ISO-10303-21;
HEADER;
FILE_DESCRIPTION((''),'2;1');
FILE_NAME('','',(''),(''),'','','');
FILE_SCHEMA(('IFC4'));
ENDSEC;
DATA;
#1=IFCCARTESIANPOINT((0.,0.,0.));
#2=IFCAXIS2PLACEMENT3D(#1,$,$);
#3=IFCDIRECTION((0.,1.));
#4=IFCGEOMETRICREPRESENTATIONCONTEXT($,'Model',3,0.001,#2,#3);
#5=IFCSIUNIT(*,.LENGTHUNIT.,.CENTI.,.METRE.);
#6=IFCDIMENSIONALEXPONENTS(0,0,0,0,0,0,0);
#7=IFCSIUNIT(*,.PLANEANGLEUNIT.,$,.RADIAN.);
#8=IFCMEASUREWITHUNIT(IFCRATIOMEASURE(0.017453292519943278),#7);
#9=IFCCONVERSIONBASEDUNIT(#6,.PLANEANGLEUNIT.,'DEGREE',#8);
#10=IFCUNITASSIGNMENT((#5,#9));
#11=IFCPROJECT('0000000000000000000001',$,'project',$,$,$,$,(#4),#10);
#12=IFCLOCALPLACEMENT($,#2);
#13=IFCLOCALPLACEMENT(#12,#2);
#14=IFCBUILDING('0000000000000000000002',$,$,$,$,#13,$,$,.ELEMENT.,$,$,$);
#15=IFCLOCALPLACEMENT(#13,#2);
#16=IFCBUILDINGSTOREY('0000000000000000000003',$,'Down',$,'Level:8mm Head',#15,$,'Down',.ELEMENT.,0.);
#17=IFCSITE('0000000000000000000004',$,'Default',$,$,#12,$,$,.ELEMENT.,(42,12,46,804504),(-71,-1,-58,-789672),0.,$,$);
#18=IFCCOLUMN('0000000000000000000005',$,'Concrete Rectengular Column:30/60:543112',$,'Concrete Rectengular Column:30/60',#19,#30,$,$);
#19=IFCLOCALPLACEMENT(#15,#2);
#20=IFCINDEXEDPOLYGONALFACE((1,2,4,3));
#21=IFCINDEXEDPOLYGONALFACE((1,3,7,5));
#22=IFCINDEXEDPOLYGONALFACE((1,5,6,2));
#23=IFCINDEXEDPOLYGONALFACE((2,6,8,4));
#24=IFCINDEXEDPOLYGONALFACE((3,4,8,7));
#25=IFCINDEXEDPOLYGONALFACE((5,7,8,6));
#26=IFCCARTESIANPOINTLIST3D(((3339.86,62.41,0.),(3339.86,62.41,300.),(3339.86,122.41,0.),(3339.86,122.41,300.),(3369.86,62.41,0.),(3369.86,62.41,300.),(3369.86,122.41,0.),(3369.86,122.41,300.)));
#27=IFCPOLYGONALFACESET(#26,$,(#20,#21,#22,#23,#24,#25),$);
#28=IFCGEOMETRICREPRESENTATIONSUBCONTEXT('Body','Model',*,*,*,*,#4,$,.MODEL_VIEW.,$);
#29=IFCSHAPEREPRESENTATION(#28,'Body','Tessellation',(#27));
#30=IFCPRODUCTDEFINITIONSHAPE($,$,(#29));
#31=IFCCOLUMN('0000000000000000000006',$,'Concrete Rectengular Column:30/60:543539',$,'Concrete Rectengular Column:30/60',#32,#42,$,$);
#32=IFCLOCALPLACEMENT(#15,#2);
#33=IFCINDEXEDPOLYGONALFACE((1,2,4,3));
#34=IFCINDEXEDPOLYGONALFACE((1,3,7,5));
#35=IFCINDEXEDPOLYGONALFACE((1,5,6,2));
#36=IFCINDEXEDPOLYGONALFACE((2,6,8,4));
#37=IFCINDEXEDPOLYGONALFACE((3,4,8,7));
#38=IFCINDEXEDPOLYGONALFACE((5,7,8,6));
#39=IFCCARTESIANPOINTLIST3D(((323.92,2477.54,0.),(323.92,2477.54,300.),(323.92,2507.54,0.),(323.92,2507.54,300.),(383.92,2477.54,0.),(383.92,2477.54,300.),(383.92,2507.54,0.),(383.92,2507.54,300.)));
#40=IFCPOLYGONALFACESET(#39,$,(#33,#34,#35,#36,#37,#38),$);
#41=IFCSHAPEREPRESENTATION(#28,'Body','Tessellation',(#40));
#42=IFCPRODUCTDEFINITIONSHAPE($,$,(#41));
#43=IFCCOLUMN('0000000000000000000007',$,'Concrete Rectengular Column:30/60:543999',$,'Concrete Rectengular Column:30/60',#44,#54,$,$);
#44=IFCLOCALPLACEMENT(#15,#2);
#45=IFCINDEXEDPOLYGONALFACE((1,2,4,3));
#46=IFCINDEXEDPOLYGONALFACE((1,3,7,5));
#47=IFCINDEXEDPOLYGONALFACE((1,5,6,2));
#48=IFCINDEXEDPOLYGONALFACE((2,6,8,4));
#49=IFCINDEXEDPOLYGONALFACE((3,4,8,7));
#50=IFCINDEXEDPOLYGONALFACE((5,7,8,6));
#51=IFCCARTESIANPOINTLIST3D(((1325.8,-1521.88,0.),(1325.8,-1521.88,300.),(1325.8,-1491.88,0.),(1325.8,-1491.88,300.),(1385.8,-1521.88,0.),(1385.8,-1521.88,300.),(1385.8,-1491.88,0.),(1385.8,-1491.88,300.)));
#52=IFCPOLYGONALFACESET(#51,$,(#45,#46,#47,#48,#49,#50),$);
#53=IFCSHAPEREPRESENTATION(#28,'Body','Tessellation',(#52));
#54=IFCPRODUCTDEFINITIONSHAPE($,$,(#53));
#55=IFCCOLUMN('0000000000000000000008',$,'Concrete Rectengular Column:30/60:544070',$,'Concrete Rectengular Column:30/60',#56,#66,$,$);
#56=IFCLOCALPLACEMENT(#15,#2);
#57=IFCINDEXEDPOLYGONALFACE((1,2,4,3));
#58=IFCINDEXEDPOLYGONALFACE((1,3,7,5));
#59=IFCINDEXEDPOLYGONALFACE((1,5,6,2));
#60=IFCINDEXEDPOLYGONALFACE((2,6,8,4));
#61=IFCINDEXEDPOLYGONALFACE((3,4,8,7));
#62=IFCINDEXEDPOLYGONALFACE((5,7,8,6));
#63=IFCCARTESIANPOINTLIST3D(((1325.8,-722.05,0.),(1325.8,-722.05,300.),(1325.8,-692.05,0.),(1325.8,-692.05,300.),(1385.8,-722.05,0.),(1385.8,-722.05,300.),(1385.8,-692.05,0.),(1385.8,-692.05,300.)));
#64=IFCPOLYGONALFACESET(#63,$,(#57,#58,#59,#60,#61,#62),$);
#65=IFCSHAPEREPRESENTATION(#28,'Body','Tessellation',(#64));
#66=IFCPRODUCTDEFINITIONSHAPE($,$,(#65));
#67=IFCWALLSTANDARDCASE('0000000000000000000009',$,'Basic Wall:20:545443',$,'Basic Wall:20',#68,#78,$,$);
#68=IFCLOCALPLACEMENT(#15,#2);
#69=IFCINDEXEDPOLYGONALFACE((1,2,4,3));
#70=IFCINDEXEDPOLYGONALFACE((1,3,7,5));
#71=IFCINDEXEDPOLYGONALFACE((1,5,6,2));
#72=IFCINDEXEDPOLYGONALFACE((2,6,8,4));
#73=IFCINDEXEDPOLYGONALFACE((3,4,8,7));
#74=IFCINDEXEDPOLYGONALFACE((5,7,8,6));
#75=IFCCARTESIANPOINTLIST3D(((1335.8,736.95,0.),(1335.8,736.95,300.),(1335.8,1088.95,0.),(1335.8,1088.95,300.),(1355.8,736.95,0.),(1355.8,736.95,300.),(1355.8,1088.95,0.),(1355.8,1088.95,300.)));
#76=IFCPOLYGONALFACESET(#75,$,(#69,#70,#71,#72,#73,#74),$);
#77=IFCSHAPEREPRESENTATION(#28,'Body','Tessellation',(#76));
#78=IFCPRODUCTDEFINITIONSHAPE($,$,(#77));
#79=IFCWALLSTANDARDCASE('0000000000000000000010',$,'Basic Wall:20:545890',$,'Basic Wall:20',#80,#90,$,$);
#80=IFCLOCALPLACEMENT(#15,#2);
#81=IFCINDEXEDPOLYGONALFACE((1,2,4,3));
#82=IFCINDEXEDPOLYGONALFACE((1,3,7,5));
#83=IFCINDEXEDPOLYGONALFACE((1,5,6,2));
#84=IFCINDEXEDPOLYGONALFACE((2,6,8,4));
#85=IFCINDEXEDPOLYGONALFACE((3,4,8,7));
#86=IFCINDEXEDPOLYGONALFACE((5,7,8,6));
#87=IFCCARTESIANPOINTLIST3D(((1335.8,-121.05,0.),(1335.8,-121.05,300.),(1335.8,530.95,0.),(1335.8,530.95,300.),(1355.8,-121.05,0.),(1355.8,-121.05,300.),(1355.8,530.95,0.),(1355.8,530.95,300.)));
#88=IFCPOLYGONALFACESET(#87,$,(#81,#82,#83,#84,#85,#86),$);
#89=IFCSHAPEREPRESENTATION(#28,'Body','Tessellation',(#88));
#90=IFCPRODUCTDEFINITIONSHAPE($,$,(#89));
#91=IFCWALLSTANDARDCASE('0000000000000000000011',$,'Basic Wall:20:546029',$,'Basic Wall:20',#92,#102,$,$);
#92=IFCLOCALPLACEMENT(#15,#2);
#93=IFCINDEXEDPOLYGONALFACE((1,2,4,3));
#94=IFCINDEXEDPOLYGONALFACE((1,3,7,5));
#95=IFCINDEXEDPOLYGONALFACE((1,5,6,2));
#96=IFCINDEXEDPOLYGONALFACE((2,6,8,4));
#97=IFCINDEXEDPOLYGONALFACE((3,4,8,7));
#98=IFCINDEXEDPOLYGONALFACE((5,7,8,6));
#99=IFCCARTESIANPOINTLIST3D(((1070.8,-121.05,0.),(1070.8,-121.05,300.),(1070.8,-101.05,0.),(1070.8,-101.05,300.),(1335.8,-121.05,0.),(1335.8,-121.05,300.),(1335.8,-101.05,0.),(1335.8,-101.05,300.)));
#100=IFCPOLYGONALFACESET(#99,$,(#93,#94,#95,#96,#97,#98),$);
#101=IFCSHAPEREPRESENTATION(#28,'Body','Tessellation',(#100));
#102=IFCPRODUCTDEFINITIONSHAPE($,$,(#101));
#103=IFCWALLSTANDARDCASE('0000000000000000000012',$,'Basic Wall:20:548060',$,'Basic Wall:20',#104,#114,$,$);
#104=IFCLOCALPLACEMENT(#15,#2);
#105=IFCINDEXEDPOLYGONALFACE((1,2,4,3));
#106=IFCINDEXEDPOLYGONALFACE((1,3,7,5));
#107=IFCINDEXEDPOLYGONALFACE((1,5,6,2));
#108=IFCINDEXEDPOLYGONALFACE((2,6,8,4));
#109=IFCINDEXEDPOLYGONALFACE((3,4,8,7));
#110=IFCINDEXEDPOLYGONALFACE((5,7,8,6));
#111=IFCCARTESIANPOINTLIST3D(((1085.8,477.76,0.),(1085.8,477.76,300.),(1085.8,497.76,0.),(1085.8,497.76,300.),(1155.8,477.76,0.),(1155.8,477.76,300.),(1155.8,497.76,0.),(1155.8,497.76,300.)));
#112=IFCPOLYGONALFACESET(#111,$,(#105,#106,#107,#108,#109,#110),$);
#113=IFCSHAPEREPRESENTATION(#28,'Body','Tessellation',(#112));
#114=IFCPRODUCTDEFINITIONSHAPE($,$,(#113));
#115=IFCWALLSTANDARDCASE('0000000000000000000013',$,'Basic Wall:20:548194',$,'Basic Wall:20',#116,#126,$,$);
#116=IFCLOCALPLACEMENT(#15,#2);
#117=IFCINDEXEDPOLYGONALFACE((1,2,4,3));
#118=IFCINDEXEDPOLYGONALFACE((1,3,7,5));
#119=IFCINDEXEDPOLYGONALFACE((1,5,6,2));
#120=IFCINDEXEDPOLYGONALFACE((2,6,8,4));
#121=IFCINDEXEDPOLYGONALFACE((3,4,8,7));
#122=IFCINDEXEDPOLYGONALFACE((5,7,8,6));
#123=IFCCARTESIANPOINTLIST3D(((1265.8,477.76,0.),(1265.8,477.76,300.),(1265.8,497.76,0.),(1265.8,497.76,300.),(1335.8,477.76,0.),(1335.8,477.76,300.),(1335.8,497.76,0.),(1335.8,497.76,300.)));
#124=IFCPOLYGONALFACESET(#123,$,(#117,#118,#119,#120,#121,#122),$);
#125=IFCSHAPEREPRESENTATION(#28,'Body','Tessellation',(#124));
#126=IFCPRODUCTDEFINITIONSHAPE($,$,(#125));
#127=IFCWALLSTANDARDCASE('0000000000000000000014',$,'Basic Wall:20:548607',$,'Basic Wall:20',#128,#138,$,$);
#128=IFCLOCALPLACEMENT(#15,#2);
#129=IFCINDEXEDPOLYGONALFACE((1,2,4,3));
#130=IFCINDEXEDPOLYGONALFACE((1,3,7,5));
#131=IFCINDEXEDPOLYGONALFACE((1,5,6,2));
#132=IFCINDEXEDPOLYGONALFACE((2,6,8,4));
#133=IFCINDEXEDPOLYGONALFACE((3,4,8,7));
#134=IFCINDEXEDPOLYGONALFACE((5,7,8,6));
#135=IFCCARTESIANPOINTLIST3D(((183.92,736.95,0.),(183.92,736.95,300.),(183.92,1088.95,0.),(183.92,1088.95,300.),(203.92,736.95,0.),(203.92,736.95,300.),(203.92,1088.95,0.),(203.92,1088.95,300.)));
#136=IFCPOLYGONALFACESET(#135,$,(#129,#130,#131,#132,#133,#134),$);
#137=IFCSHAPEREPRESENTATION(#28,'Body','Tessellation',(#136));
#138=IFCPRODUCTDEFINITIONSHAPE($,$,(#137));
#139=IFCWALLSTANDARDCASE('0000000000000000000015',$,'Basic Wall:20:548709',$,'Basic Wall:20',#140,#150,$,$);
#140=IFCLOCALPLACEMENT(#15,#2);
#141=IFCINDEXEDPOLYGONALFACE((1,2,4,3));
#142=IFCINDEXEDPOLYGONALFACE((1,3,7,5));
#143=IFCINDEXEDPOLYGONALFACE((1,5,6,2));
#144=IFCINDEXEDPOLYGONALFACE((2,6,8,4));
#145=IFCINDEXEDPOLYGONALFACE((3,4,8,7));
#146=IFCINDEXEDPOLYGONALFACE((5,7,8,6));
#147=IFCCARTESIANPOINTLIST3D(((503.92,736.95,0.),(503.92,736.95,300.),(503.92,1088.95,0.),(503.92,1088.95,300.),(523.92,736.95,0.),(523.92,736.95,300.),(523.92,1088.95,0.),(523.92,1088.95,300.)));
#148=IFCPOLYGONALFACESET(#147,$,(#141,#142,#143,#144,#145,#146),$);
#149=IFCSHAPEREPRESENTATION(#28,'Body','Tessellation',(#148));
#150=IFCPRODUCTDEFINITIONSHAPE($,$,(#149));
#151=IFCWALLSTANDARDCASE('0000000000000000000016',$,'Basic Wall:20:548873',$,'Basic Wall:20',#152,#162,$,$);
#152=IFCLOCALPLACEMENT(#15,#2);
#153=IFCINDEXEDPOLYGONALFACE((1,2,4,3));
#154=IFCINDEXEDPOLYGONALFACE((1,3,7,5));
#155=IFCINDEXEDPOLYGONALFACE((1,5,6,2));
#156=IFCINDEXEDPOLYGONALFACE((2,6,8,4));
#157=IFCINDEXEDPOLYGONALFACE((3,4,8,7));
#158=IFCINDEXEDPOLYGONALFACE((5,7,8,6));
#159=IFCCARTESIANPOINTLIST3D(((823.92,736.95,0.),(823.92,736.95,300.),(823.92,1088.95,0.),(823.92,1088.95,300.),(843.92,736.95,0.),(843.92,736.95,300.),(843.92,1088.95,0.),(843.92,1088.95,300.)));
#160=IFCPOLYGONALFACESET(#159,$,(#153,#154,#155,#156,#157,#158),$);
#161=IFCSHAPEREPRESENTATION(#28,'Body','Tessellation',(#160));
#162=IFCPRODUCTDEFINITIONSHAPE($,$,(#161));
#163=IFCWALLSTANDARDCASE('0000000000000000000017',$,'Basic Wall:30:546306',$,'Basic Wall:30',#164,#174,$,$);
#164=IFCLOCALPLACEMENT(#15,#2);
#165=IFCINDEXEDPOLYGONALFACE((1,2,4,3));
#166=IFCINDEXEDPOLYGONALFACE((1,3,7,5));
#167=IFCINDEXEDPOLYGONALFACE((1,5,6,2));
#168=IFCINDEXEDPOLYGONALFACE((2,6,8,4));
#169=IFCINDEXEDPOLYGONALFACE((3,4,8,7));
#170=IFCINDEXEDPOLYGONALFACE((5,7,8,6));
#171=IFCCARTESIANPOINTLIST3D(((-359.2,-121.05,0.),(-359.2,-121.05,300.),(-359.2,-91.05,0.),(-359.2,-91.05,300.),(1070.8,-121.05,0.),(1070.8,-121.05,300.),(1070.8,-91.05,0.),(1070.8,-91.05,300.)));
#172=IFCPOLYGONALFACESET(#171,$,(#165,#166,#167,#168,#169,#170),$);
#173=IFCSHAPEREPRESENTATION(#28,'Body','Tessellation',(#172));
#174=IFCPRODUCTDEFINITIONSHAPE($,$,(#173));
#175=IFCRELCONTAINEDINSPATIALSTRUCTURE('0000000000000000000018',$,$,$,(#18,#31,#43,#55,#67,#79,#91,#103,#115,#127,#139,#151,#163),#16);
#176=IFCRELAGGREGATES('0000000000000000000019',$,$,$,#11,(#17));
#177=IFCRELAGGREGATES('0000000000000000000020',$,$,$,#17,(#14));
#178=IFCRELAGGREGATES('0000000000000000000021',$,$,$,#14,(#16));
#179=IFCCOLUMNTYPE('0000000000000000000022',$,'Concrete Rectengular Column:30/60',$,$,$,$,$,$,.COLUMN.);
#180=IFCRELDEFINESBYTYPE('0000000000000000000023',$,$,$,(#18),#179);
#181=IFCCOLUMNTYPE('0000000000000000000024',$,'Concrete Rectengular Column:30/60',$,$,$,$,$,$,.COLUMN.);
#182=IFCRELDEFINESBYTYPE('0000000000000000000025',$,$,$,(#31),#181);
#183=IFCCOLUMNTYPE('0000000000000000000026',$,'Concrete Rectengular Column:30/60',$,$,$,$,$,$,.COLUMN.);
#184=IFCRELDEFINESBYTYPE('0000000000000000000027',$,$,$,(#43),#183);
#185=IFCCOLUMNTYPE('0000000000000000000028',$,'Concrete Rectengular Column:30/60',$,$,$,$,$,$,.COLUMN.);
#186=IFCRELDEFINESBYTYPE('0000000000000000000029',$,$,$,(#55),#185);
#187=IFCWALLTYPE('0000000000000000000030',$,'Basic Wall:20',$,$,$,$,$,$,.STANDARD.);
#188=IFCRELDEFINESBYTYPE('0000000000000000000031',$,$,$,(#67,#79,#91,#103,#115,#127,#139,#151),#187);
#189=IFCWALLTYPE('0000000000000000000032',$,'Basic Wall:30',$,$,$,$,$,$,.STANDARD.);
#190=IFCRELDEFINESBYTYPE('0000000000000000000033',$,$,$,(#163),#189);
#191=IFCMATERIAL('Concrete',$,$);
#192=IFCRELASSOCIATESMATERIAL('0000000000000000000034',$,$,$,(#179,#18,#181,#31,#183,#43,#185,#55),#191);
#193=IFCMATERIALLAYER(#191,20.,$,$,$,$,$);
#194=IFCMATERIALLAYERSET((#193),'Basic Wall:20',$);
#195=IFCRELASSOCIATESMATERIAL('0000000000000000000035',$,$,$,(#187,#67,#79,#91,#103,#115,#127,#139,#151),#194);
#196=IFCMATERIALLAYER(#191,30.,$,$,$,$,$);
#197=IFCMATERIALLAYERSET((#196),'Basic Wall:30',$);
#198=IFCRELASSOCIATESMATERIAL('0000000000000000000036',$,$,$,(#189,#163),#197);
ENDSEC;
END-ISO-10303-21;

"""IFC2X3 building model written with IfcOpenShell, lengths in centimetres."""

from ifc_helpers import new_model, entity, si_unit, converted_unit, direction, frame, frame_2d, origin, origin_2d_with_axis, place, context, subcontext, project, spatial, rectangle, extrude, source, transform, mapped, material, layer, layer_set, layer_usage, type_object, type_shapes, element, save


model = new_model("IFC2X3")

# Units and contexts
model_context = context("Model", 3, precision=0.001, world=origin(), true_north=direction((0.0, 1.0)))
body_context = subcontext(model_context, "Body", "Model", "MODEL_VIEW")
ifc_project = project(units=[si_unit("LENGTHUNIT", "METRE", prefix="CENTI"), converted_unit("PLANEANGLEUNIT", "DEGREE", entity("IfcRatioMeasure", 0.017453292519943278), si_unit("PLANEANGLEUNIT", "RADIAN"), dimensions=[0, 0, 0, 0, 0, 0, 0])], contexts=[model_context])

# Site, building, storey
site_placement = place(None, origin())
site = spatial("IfcSite", under=ifc_project, at=site_placement, Name="Default", CompositionType="ELEMENT", RefLatitude=(42, 12, 46, 804504), RefLongitude=(-71, -1, -58, -789672), RefElevation=0.0)
building_placement = place(site_placement, origin())
building = spatial("IfcBuilding", under=site, at=building_placement, CompositionType="ELEMENT")
storey_placement = place(building_placement, origin())
storey = spatial("IfcBuildingStorey", under=building, at=storey_placement, Name="Down", ObjectType="Level:8mm Head", LongName="Down", CompositionType="ELEMENT", Elevation=0.0)

# Columns
ifc_material = material(Name="Concrete")
column_type_1 = type_object("IfcColumnType", Name="Concrete Rectengular Column:30/60", PredefinedType="COLUMN", material=ifc_material)
shared_shape_1 = source(origin(), body_context, "Body", "SweptSolid", [
    extrude(rectangle(XDim=60.0, YDim=30.0, at=origin_2d_with_axis()), frame((3354.86, 92.41, 0.0), z_axis=(0.0, 0.0, 1.0), x_axis=(0.0, -1.0, 0.0)), (0.0, 0.0, 1.0), 300.0),
])
type_shapes(column_type_1, [shared_shape_1])
column_1_placement = place(storey_placement, origin())
element("IfcColumn", 1, at=column_1_placement, inside=storey, type_object=column_type_1, material=ifc_material, Name="Concrete Rectengular Column:30/60:543112", ObjectType="Concrete Rectengular Column:30/60", context=body_context, shape_type="MappedRepresentation", body=[
    mapped(shared_shape_1, transform((0.0, 0.0, 0.0), scale=1.0)),
])
column_type_2 = type_object("IfcColumnType", Name="Concrete Rectengular Column:30/60", PredefinedType="COLUMN", material=ifc_material)
shared_shape_2 = source(origin(), body_context, "Body", "SweptSolid", [
    extrude(rectangle(XDim=30.0, YDim=60.0, at=origin_2d_with_axis()), frame((353.92, 2492.54, 0.0), z_axis=(0.0, 0.0, 1.0), x_axis=(0.0, -1.0, 0.0)), (0.0, 0.0, 1.0), 300.0),
])
type_shapes(column_type_2, [shared_shape_2])
column_2_placement = place(storey_placement, origin())
element("IfcColumn", 2, at=column_2_placement, inside=storey, type_object=column_type_2, material=ifc_material, Name="Concrete Rectengular Column:30/60:543539", ObjectType="Concrete Rectengular Column:30/60", context=body_context, shape_type="MappedRepresentation", body=[
    mapped(shared_shape_2, transform((0.0, 0.0, 0.0), scale=1.0)),
])
column_type_3 = type_object("IfcColumnType", Name="Concrete Rectengular Column:30/60", PredefinedType="COLUMN", material=ifc_material)
shared_shape_3 = source(origin(), body_context, "Body", "SweptSolid", [
    extrude(rectangle(XDim=30.0, YDim=60.0, at=frame_2d((0.0, 0.0), x_axis=(1.0, 0.0))), frame((1355.8, -1506.88, 0.0), z_axis=(0.0, 0.0, 1.0), x_axis=(0.0, -1.0, 0.0)), (0.0, 0.0, 1.0), 300.0),
])
type_shapes(column_type_3, [shared_shape_3])
column_3_placement = place(storey_placement, origin())
element("IfcColumn", 3, at=column_3_placement, inside=storey, type_object=column_type_3, material=ifc_material, Name="Concrete Rectengular Column:30/60:543999", ObjectType="Concrete Rectengular Column:30/60", context=body_context, shape_type="MappedRepresentation", body=[
    mapped(shared_shape_3, transform((0.0, 0.0, 0.0), scale=1.0)),
])
column_type_4 = type_object("IfcColumnType", Name="Concrete Rectengular Column:30/60", PredefinedType="COLUMN", material=ifc_material)
shared_shape_4 = source(origin(), body_context, "Body", "SweptSolid", [
    extrude(rectangle(XDim=30.0, YDim=60.0, at=frame_2d((0.0, 0.0), x_axis=(1.0, 0.0))), frame((1355.8, -707.05, 0.0), z_axis=(0.0, 0.0, 1.0), x_axis=(0.0, -1.0, 0.0)), (0.0, 0.0, 1.0), 300.0),
])
type_shapes(column_type_4, [shared_shape_4])
column_4_placement = place(storey_placement, origin())
element("IfcColumn", 4, at=column_4_placement, inside=storey, type_object=column_type_4, material=ifc_material, Name="Concrete Rectengular Column:30/60:544070", ObjectType="Concrete Rectengular Column:30/60", context=body_context, shape_type="MappedRepresentation", body=[
    mapped(shared_shape_4, transform((0.0, 0.0, 0.0), scale=1.0)),
])

# Walls
ifc_layer_1 = layer(ifc_material, 20.0)
ifc_layer_set_1 = layer_set([ifc_layer_1], Name="Basic Wall:20")
ifc_layer_usage_1 = layer_usage(ifc_layer_set_1, "AXIS2", "NEGATIVE", 10.0)
wall_type_1 = type_object("IfcWallType", Name="Basic Wall:20", PredefinedType="STANDARD", material=ifc_layer_set_1)
wall_1_placement = place(storey_placement, frame((1345.8, 1088.95, 0.0), z_axis=(0.0, 0.0, 1.0), x_axis=(0.0, -1.0, 0.0)))
element("IfcWallStandardCase", 5, at=wall_1_placement, inside=storey, type_object=wall_type_1, material=ifc_layer_usage_1, Name="Basic Wall:20:545443", ObjectType="Basic Wall:20", context=body_context, shape_type="SweptSolid", body=[
    extrude(rectangle(XDim=352.0, YDim=20.0, at=frame_2d((176.0, 0.0), x_axis=(-1.0, 0.0))), origin(), (0.0, 0.0, 1.0), 300.0),
])
ifc_layer_usage_2 = layer_usage(ifc_layer_set_1, "AXIS2", "NEGATIVE", 10.0)
wall_2_placement = place(storey_placement, frame((1345.8, 530.95, 0.0), z_axis=(0.0, 0.0, 1.0), x_axis=(0.0, -1.0, 0.0)))
element("IfcWallStandardCase", 6, at=wall_2_placement, inside=storey, type_object=wall_type_1, material=ifc_layer_usage_2, Name="Basic Wall:20:545890", ObjectType="Basic Wall:20", context=body_context, shape_type="SweptSolid", body=[
    extrude(rectangle(XDim=652.0, YDim=20.0, at=frame_2d((326.0, 0.0), x_axis=(-1.0, 0.0))), origin(), (0.0, 0.0, 1.0), 300.0),
])
ifc_layer_usage_3 = layer_usage(ifc_layer_set_1, "AXIS2", "NEGATIVE", 10.0)
wall_3_placement = place(storey_placement, frame((1335.8, -111.05, 0.0), z_axis=(0.0, 0.0, 1.0), x_axis=(-1.0, 0.0, 0.0)))
element("IfcWallStandardCase", 7, at=wall_3_placement, inside=storey, type_object=wall_type_1, material=ifc_layer_usage_3, Name="Basic Wall:20:546029", ObjectType="Basic Wall:20", context=body_context, shape_type="SweptSolid", body=[
    extrude(rectangle(XDim=265.0, YDim=20.0, at=frame_2d((132.5, 0.0), x_axis=(-1.0, 0.0))), origin(), (0.0, 0.0, 1.0), 300.0),
])
ifc_layer_usage_4 = layer_usage(ifc_layer_set_1, "AXIS2", "NEGATIVE", 10.0)
wall_4_placement = place(storey_placement, frame((1085.8, 487.76, 0.0)))
element("IfcWallStandardCase", 8, at=wall_4_placement, inside=storey, type_object=wall_type_1, material=ifc_layer_usage_4, Name="Basic Wall:20:548060", ObjectType="Basic Wall:20", context=body_context, shape_type="SweptSolid", body=[
    extrude(rectangle(XDim=70.0, YDim=20.0, at=frame_2d((35.0, 0.0), x_axis=(-1.0, 0.0))), origin(), (0.0, 0.0, 1.0), 300.0),
])
ifc_layer_usage_5 = layer_usage(ifc_layer_set_1, "AXIS2", "NEGATIVE", 10.0)
wall_5_placement = place(storey_placement, frame((1265.8, 487.76, 0.0)))
element("IfcWallStandardCase", 9, at=wall_5_placement, inside=storey, type_object=wall_type_1, material=ifc_layer_usage_5, Name="Basic Wall:20:548194", ObjectType="Basic Wall:20", context=body_context, shape_type="SweptSolid", body=[
    extrude(rectangle(XDim=70.0, YDim=20.0, at=frame_2d((35.0, 0.0), x_axis=(-1.0, 0.0))), origin(), (0.0, 0.0, 1.0), 300.0),
])
ifc_layer_usage_6 = layer_usage(ifc_layer_set_1, "AXIS2", "POSITIVE", -10.0)
wall_6_placement = place(storey_placement, frame((193.92, 1088.95, 0.0), z_axis=(0.0, 0.0, 1.0), x_axis=(0.0, -1.0, 0.0)))
element("IfcWallStandardCase", 10, at=wall_6_placement, inside=storey, type_object=wall_type_1, material=ifc_layer_usage_6, Name="Basic Wall:20:548607", ObjectType="Basic Wall:20", context=body_context, shape_type="SweptSolid", body=[
    extrude(rectangle(XDim=352.0, YDim=20.0, at=frame_2d((176.0, 0.0), x_axis=(-1.0, 0.0))), origin(), (0.0, 0.0, 1.0), 300.0),
])
ifc_layer_usage_7 = layer_usage(ifc_layer_set_1, "AXIS2", "POSITIVE", -10.0)
wall_7_placement = place(storey_placement, frame((513.92, 1088.95, 0.0), z_axis=(0.0, 0.0, 1.0), x_axis=(0.0, -1.0, 0.0)))
element("IfcWallStandardCase", 11, at=wall_7_placement, inside=storey, type_object=wall_type_1, material=ifc_layer_usage_7, Name="Basic Wall:20:548709", ObjectType="Basic Wall:20", context=body_context, shape_type="SweptSolid", body=[
    extrude(rectangle(XDim=352.0, YDim=20.0, at=frame_2d((176.0, 0.0), x_axis=(-1.0, 0.0))), origin(), (0.0, 0.0, 1.0), 300.0),
])
ifc_layer_usage_8 = layer_usage(ifc_layer_set_1, "AXIS2", "POSITIVE", -10.0)
wall_8_placement = place(storey_placement, frame((833.92, 1088.95, 0.0), z_axis=(0.0, 0.0, 1.0), x_axis=(0.0, -1.0, 0.0)))
element("IfcWallStandardCase", 12, at=wall_8_placement, inside=storey, type_object=wall_type_1, material=ifc_layer_usage_8, Name="Basic Wall:20:548873", ObjectType="Basic Wall:20", context=body_context, shape_type="SweptSolid", body=[
    extrude(rectangle(XDim=352.0, YDim=20.0, at=frame_2d((176.0, 0.0), x_axis=(-1.0, 0.0))), origin(), (0.0, 0.0, 1.0), 300.0),
])
ifc_layer_2 = layer(ifc_material, 30.0)
ifc_layer_set_2 = layer_set([ifc_layer_2], Name="Basic Wall:30")
ifc_layer_usage_9 = layer_usage(ifc_layer_set_2, "AXIS2", "NEGATIVE", 15.0)
wall_type_2 = type_object("IfcWallType", Name="Basic Wall:30", PredefinedType="STANDARD", material=ifc_layer_set_2)
wall_9_placement = place(storey_placement, frame((1070.8, -106.05, 0.0), z_axis=(0.0, 0.0, 1.0), x_axis=(-1.0, 0.0, 0.0)))
element("IfcWallStandardCase", 13, at=wall_9_placement, inside=storey, type_object=wall_type_2, material=ifc_layer_usage_9, Name="Basic Wall:30:546306", ObjectType="Basic Wall:30", context=body_context, shape_type="SweptSolid", body=[
    extrude(rectangle(XDim=1430.0, YDim=30.0, at=frame_2d((715.0, 0.0), x_axis=(-1.0, 0.0))), origin(), (0.0, 0.0, 1.0), 300.0),
])

save(model, "model.ifc")
